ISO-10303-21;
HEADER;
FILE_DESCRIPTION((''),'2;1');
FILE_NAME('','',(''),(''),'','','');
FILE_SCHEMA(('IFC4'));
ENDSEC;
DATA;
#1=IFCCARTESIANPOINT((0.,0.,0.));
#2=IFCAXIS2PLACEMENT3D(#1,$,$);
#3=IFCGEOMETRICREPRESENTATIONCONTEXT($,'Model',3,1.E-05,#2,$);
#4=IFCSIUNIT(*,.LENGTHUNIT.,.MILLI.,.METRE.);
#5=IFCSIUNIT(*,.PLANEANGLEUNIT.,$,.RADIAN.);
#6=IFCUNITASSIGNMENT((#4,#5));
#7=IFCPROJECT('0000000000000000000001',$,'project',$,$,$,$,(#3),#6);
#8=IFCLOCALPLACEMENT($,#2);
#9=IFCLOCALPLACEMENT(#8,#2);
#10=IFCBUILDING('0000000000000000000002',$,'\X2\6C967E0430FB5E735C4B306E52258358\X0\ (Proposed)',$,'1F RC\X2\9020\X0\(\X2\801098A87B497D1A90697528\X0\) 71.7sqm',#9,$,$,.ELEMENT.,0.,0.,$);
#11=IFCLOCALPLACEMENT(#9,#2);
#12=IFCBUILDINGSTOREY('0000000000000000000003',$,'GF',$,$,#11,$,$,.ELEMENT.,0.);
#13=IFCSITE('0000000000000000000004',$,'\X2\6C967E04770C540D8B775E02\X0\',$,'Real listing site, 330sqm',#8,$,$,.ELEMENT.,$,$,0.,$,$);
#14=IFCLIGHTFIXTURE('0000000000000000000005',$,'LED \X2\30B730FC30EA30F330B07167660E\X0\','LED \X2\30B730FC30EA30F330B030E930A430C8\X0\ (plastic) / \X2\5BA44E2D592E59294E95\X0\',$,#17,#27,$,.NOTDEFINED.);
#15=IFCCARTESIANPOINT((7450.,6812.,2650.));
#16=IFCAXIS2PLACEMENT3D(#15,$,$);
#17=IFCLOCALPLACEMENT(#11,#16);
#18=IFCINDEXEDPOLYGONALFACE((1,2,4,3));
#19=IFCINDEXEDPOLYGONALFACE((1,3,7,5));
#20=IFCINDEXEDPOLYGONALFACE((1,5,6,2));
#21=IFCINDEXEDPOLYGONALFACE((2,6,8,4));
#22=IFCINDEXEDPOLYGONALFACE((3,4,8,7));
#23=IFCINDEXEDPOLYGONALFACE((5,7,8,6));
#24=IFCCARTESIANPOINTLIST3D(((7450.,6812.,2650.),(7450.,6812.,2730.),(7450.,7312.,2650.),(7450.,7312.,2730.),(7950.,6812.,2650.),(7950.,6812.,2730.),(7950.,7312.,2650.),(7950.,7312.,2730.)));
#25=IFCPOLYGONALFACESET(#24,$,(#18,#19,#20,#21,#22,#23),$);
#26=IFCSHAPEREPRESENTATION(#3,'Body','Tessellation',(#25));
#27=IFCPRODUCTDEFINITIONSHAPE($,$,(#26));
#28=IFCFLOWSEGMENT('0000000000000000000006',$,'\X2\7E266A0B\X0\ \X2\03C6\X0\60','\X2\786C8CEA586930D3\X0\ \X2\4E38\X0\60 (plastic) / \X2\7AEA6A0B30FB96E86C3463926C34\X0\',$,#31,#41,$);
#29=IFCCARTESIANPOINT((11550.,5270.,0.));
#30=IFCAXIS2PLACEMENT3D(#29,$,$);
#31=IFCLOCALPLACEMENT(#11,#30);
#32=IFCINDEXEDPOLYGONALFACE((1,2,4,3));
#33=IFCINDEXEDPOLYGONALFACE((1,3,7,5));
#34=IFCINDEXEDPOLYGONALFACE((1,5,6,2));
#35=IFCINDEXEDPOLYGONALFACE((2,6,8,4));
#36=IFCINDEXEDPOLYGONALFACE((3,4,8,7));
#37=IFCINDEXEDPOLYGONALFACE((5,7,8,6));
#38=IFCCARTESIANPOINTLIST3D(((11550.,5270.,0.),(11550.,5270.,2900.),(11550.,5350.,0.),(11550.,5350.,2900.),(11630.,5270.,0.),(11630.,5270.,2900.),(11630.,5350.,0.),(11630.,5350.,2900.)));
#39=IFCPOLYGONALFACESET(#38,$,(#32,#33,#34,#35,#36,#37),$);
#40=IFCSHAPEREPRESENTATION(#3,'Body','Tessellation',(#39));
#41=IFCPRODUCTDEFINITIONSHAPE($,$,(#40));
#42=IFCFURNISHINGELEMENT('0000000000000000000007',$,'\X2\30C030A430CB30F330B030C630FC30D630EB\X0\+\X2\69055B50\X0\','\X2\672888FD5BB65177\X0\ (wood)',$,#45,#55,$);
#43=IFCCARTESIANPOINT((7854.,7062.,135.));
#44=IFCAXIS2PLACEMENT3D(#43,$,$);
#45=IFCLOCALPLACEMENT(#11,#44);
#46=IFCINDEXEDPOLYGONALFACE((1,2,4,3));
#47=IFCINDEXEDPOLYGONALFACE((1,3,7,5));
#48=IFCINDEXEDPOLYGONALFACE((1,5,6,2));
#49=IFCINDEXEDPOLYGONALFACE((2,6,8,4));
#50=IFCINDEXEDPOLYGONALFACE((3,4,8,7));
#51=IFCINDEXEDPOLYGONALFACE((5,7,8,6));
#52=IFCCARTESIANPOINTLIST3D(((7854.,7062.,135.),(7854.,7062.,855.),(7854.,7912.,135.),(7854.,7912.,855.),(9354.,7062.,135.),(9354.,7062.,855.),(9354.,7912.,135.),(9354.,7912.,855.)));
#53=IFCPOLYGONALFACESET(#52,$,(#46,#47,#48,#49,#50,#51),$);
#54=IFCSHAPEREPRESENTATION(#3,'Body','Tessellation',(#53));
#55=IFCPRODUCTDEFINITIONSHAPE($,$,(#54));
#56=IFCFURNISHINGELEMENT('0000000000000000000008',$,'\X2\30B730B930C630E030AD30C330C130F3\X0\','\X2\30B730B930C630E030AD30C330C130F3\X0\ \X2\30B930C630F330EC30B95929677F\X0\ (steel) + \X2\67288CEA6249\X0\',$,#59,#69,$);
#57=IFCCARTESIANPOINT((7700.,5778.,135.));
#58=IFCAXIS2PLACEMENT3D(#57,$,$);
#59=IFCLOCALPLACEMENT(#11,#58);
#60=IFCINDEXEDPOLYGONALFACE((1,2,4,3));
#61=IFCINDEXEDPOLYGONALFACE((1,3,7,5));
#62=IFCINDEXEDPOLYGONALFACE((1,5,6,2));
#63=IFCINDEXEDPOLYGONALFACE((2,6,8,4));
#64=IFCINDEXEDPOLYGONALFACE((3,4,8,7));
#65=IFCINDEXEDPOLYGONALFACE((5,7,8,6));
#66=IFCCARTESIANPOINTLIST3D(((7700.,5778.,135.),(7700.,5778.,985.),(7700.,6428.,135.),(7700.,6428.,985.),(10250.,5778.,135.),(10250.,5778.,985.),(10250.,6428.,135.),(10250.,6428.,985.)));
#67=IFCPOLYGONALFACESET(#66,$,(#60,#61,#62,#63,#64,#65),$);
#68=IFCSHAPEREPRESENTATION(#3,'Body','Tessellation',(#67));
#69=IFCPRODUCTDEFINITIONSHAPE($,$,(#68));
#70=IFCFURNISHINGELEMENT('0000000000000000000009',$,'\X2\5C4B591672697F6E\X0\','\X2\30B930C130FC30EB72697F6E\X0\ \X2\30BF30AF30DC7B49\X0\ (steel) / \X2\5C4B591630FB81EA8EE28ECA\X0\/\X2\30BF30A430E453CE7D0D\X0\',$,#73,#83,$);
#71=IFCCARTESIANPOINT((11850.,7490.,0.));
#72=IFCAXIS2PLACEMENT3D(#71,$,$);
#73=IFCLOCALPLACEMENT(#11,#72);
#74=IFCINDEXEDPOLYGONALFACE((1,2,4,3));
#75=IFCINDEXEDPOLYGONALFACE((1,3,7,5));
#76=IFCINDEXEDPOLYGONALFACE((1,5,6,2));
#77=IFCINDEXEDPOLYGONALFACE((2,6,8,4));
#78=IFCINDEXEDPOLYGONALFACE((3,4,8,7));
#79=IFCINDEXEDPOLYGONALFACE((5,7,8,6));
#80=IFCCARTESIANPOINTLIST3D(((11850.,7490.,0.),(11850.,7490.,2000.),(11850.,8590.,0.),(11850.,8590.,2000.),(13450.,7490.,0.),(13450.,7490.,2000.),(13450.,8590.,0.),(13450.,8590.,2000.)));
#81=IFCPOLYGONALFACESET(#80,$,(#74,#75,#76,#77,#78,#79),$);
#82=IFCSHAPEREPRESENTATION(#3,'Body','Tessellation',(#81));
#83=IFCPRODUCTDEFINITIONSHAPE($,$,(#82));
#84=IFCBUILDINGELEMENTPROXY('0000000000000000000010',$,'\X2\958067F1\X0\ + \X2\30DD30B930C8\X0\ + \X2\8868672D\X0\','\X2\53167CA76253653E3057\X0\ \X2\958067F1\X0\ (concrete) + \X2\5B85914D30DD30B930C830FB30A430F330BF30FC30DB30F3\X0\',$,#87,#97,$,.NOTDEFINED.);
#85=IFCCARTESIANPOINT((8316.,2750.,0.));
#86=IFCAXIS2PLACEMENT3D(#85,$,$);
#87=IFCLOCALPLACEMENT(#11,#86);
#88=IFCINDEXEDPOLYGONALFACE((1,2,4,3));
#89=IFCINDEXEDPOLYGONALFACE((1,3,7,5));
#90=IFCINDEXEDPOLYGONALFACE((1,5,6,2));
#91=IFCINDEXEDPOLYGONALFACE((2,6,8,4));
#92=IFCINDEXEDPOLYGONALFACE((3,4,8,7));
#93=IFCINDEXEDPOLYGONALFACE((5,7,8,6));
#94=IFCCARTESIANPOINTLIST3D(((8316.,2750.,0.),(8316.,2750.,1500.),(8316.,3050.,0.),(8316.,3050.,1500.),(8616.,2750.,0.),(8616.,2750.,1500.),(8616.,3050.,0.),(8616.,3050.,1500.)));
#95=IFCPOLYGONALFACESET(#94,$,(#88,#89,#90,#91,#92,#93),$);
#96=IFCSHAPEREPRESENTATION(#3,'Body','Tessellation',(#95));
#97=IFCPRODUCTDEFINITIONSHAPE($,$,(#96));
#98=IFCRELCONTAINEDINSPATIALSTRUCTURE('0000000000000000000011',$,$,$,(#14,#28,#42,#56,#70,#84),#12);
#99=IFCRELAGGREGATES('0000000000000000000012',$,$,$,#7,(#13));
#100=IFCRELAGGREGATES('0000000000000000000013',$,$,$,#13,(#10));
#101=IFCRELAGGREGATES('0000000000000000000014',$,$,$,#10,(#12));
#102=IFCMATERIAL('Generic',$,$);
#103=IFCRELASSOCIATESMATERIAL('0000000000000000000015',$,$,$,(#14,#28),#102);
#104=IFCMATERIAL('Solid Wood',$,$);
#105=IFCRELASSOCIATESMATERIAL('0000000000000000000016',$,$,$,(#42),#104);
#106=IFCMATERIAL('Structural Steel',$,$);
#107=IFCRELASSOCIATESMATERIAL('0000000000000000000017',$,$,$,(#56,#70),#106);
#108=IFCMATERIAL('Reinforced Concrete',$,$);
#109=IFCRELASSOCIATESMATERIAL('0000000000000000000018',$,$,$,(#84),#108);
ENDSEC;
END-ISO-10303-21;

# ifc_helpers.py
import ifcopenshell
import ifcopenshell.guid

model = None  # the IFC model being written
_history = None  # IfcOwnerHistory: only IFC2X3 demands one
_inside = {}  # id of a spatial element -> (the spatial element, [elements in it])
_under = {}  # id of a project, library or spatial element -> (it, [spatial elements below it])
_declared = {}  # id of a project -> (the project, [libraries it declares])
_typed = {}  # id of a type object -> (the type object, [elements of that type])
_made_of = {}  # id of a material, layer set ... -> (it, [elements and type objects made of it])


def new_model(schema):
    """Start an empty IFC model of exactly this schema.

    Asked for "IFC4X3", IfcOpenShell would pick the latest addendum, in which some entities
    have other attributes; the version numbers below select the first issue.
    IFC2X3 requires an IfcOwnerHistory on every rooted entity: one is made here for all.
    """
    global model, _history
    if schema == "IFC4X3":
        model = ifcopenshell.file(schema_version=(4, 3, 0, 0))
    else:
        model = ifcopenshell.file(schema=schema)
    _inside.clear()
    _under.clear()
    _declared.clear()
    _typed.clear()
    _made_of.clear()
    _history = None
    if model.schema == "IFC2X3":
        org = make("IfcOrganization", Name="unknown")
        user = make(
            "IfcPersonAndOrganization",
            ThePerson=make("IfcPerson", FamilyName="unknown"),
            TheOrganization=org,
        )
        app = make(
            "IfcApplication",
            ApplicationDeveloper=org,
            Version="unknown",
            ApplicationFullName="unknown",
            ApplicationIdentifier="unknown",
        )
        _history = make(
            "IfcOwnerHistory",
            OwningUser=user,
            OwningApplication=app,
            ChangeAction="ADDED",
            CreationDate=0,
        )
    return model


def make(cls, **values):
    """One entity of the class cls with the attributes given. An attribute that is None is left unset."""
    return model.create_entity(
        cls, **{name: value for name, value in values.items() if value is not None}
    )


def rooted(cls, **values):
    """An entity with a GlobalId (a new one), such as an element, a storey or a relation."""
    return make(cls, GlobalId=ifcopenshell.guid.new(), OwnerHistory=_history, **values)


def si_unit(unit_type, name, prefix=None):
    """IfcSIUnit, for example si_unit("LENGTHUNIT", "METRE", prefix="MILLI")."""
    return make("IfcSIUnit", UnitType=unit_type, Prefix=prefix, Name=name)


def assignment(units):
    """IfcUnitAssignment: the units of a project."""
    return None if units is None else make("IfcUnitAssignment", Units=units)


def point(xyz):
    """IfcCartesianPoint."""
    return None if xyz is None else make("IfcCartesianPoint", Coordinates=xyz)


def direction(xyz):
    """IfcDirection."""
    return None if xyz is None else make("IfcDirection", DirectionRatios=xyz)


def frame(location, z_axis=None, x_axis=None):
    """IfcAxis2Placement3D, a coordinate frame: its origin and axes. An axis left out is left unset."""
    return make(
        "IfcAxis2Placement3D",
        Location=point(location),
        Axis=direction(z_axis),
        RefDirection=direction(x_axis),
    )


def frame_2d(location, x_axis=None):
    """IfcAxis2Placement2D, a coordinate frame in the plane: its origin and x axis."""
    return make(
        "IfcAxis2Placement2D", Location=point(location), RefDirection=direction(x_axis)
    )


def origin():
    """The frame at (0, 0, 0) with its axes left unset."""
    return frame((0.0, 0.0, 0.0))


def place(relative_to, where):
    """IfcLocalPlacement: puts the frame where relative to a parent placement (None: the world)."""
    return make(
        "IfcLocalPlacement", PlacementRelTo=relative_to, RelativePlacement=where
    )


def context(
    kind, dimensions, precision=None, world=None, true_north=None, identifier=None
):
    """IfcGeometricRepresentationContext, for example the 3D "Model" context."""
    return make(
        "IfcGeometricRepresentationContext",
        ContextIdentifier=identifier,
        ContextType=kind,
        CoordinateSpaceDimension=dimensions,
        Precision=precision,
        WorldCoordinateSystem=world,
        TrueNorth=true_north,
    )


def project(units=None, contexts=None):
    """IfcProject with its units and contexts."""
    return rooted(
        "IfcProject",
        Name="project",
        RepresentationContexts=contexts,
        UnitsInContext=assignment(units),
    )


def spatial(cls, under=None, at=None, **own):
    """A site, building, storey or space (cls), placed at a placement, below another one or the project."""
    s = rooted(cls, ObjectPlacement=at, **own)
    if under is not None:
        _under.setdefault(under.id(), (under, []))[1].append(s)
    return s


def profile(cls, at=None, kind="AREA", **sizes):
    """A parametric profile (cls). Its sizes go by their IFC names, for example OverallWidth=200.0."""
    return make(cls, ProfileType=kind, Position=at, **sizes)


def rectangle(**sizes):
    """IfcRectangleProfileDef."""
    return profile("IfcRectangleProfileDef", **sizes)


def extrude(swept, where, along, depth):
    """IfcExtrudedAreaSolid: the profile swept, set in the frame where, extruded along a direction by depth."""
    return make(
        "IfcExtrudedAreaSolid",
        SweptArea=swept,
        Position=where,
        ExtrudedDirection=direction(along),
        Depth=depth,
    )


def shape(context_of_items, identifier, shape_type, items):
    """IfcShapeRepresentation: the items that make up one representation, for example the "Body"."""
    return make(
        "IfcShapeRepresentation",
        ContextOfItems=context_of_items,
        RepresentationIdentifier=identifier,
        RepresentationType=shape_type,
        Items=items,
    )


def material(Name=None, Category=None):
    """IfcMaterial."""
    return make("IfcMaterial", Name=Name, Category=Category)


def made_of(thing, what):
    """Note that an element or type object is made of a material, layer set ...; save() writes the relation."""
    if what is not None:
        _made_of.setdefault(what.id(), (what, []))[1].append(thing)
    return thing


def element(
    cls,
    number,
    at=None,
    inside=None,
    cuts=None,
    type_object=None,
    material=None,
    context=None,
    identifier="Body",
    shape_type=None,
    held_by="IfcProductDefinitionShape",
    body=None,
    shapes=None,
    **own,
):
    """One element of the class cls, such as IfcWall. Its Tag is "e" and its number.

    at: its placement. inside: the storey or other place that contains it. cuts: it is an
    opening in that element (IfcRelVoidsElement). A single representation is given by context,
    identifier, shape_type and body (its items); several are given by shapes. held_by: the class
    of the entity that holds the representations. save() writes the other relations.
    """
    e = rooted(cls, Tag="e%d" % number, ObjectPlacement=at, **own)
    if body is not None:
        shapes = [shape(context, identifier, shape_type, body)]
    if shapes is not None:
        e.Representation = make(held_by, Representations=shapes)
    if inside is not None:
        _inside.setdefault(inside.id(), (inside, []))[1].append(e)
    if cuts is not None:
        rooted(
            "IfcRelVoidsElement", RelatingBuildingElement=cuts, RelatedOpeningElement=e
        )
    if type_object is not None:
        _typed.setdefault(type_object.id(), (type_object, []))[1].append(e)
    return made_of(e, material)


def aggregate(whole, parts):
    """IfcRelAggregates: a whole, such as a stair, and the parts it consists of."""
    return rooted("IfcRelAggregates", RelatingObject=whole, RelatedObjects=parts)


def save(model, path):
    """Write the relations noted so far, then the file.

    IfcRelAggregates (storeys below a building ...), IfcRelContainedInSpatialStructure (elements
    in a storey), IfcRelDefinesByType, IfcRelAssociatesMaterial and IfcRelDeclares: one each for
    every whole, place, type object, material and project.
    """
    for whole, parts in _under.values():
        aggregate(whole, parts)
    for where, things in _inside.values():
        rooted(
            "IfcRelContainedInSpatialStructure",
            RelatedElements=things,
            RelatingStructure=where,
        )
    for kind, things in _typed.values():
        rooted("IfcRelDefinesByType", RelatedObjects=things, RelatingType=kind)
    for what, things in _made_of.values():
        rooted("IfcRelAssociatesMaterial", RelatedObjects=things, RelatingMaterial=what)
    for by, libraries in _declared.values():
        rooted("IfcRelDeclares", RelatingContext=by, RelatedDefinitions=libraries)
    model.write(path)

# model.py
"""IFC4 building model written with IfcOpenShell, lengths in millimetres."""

from ifc_helpers import new_model, si_unit, frame, frame_2d, origin, place, context, project, spatial, rectangle, extrude, material, element, save


model = new_model("IFC4")

# Units and contexts
model_context = context("Model", 3, precision=1e-05, world=origin())
ifc_project = project(units=[si_unit("LENGTHUNIT", "METRE", prefix="MILLI"), si_unit("PLANEANGLEUNIT", "RADIAN")], contexts=[model_context])

# Site, building, storey
site_placement = place(None, origin())
site = spatial("IfcSite", under=ifc_project, at=site_placement, Name="沖縄県名護市", ObjectType="Real listing site, 330sqm", CompositionType="ELEMENT", RefElevation=0.0)
building_placement = place(site_placement, origin())
building = spatial("IfcBuilding", under=site, at=building_placement, Name="沖縄・平屋の別荘 (Proposed)", ObjectType="1F RC造(耐風等級適用) 71.7sqm", CompositionType="ELEMENT", ElevationOfRefHeight=0.0, ElevationOfTerrain=0.0)
storey_placement = place(building_placement, origin())
storey = spatial("IfcBuildingStorey", under=building, at=storey_placement, Name="GF", CompositionType="ELEMENT", Elevation=0.0)

# Shared definitions
ifc_material_1 = material(Name="Solid Wood")

# Shared definitions
ifc_material_2 = material(Name="Structural Steel")

# Shared definitions
ifc_material_3 = material(Name="Reinforced Concrete")

# Shared definitions
ifc_material_4 = material(Name="Generic")

# Light fixture
light_fixture_placement = place(storey_placement, frame((7450.0, 6812.0, 2650.0)))
element("IfcLightFixture", 1, at=light_fixture_placement, inside=storey, material=ifc_material_4, Name="LED シーリング照明", Description="LED シーリングライト (plastic) / 室中央天井", PredefinedType="NOTDEFINED", context=model_context, shape_type="SweptSolid", body=[
    extrude(rectangle(XDim=500.0, YDim=500.0, at=frame_2d((250.0, 250.0))), frame((7450.0, 6812.0, 2650.0)), (0.0, 0.0, 1.0), 80.0),
])

# Flow segment
flow_segment_placement = place(storey_placement, frame((11550.0, 5270.0, 0.0)))
element("IfcFlowSegment", 2, at=flow_segment_placement, inside=storey, material=ifc_material_4, Name="縦樋 φ60", Description="硬質塩ビ 丸60 (plastic) / 竪樋・雨水排水", context=model_context, shape_type="SweptSolid", body=[
    extrude(rectangle(XDim=80.0, YDim=80.0, at=frame_2d((40.0, 40.0))), frame((11550.0, 5270.0, 0.0)), (0.0, 0.0, 1.0), 2900.0),
])

# Furnishing elements
furnishing_1_placement = place(storey_placement, frame((7854.0, 7062.0, 135.0)))
element("IfcFurnishingElement", 3, at=furnishing_1_placement, inside=storey, material=ifc_material_1, Name="ダイニングテーブル+椅子", Description="木製家具 (wood)", context=model_context, shape_type="SweptSolid", body=[
    extrude(rectangle(XDim=1500.0, YDim=850.0, at=frame_2d((750.0, 425.0))), frame((7854.0, 7062.0, 135.0)), (0.0, 0.0, 1.0), 720.0),
])
furnishing_2_placement = place(storey_placement, frame((7700.0, 5778.0, 135.0)))
element("IfcFurnishingElement", 4, at=furnishing_2_placement, inside=storey, material=ifc_material_2, Name="システムキッチン", Description="システムキッチン ステンレス天板 (steel) + 木質扉", context=model_context, shape_type="SweptSolid", body=[
    extrude(rectangle(XDim=2550.0, YDim=650.0, at=frame_2d((1275.0, 325.0))), frame((7700.0, 5778.0, 135.0)), (0.0, 0.0, 1.0), 850.0),
])
furnishing_3_placement = place(storey_placement, frame((11850.0, 7490.0, 0.0)))
element("IfcFurnishingElement", 5, at=furnishing_3_placement, inside=storey, material=ifc_material_2, Name="屋外物置", Description="スチール物置 タクボ等 (steel) / 屋外・自転車/タイヤ収納", context=model_context, shape_type="SweptSolid", body=[
    extrude(rectangle(XDim=1600.0, YDim=1100.0, at=frame_2d((800.0, 550.0))), frame((11850.0, 7490.0, 0.0)), (0.0, 0.0, 1.0), 2000.0),
])

# Building element proxy
proxy_placement = place(storey_placement, frame((8316.0, 2750.0, 0.0)))
element("IfcBuildingElementProxy", 6, at=proxy_placement, inside=storey, material=ifc_material_3, Name="門柱 + ポスト + 表札", Description="化粧打放し 門柱 (concrete) + 宅配ポスト・インターホン", PredefinedType="NOTDEFINED", context=model_context, shape_type="SweptSolid", body=[
    extrude(rectangle(XDim=300.0, YDim=300.0, at=frame_2d((150.0, 150.0))), frame((8316.0, 2750.0, 0.0)), (0.0, 0.0, 1.0), 1500.0),
])

save(model, "model.ifc")
